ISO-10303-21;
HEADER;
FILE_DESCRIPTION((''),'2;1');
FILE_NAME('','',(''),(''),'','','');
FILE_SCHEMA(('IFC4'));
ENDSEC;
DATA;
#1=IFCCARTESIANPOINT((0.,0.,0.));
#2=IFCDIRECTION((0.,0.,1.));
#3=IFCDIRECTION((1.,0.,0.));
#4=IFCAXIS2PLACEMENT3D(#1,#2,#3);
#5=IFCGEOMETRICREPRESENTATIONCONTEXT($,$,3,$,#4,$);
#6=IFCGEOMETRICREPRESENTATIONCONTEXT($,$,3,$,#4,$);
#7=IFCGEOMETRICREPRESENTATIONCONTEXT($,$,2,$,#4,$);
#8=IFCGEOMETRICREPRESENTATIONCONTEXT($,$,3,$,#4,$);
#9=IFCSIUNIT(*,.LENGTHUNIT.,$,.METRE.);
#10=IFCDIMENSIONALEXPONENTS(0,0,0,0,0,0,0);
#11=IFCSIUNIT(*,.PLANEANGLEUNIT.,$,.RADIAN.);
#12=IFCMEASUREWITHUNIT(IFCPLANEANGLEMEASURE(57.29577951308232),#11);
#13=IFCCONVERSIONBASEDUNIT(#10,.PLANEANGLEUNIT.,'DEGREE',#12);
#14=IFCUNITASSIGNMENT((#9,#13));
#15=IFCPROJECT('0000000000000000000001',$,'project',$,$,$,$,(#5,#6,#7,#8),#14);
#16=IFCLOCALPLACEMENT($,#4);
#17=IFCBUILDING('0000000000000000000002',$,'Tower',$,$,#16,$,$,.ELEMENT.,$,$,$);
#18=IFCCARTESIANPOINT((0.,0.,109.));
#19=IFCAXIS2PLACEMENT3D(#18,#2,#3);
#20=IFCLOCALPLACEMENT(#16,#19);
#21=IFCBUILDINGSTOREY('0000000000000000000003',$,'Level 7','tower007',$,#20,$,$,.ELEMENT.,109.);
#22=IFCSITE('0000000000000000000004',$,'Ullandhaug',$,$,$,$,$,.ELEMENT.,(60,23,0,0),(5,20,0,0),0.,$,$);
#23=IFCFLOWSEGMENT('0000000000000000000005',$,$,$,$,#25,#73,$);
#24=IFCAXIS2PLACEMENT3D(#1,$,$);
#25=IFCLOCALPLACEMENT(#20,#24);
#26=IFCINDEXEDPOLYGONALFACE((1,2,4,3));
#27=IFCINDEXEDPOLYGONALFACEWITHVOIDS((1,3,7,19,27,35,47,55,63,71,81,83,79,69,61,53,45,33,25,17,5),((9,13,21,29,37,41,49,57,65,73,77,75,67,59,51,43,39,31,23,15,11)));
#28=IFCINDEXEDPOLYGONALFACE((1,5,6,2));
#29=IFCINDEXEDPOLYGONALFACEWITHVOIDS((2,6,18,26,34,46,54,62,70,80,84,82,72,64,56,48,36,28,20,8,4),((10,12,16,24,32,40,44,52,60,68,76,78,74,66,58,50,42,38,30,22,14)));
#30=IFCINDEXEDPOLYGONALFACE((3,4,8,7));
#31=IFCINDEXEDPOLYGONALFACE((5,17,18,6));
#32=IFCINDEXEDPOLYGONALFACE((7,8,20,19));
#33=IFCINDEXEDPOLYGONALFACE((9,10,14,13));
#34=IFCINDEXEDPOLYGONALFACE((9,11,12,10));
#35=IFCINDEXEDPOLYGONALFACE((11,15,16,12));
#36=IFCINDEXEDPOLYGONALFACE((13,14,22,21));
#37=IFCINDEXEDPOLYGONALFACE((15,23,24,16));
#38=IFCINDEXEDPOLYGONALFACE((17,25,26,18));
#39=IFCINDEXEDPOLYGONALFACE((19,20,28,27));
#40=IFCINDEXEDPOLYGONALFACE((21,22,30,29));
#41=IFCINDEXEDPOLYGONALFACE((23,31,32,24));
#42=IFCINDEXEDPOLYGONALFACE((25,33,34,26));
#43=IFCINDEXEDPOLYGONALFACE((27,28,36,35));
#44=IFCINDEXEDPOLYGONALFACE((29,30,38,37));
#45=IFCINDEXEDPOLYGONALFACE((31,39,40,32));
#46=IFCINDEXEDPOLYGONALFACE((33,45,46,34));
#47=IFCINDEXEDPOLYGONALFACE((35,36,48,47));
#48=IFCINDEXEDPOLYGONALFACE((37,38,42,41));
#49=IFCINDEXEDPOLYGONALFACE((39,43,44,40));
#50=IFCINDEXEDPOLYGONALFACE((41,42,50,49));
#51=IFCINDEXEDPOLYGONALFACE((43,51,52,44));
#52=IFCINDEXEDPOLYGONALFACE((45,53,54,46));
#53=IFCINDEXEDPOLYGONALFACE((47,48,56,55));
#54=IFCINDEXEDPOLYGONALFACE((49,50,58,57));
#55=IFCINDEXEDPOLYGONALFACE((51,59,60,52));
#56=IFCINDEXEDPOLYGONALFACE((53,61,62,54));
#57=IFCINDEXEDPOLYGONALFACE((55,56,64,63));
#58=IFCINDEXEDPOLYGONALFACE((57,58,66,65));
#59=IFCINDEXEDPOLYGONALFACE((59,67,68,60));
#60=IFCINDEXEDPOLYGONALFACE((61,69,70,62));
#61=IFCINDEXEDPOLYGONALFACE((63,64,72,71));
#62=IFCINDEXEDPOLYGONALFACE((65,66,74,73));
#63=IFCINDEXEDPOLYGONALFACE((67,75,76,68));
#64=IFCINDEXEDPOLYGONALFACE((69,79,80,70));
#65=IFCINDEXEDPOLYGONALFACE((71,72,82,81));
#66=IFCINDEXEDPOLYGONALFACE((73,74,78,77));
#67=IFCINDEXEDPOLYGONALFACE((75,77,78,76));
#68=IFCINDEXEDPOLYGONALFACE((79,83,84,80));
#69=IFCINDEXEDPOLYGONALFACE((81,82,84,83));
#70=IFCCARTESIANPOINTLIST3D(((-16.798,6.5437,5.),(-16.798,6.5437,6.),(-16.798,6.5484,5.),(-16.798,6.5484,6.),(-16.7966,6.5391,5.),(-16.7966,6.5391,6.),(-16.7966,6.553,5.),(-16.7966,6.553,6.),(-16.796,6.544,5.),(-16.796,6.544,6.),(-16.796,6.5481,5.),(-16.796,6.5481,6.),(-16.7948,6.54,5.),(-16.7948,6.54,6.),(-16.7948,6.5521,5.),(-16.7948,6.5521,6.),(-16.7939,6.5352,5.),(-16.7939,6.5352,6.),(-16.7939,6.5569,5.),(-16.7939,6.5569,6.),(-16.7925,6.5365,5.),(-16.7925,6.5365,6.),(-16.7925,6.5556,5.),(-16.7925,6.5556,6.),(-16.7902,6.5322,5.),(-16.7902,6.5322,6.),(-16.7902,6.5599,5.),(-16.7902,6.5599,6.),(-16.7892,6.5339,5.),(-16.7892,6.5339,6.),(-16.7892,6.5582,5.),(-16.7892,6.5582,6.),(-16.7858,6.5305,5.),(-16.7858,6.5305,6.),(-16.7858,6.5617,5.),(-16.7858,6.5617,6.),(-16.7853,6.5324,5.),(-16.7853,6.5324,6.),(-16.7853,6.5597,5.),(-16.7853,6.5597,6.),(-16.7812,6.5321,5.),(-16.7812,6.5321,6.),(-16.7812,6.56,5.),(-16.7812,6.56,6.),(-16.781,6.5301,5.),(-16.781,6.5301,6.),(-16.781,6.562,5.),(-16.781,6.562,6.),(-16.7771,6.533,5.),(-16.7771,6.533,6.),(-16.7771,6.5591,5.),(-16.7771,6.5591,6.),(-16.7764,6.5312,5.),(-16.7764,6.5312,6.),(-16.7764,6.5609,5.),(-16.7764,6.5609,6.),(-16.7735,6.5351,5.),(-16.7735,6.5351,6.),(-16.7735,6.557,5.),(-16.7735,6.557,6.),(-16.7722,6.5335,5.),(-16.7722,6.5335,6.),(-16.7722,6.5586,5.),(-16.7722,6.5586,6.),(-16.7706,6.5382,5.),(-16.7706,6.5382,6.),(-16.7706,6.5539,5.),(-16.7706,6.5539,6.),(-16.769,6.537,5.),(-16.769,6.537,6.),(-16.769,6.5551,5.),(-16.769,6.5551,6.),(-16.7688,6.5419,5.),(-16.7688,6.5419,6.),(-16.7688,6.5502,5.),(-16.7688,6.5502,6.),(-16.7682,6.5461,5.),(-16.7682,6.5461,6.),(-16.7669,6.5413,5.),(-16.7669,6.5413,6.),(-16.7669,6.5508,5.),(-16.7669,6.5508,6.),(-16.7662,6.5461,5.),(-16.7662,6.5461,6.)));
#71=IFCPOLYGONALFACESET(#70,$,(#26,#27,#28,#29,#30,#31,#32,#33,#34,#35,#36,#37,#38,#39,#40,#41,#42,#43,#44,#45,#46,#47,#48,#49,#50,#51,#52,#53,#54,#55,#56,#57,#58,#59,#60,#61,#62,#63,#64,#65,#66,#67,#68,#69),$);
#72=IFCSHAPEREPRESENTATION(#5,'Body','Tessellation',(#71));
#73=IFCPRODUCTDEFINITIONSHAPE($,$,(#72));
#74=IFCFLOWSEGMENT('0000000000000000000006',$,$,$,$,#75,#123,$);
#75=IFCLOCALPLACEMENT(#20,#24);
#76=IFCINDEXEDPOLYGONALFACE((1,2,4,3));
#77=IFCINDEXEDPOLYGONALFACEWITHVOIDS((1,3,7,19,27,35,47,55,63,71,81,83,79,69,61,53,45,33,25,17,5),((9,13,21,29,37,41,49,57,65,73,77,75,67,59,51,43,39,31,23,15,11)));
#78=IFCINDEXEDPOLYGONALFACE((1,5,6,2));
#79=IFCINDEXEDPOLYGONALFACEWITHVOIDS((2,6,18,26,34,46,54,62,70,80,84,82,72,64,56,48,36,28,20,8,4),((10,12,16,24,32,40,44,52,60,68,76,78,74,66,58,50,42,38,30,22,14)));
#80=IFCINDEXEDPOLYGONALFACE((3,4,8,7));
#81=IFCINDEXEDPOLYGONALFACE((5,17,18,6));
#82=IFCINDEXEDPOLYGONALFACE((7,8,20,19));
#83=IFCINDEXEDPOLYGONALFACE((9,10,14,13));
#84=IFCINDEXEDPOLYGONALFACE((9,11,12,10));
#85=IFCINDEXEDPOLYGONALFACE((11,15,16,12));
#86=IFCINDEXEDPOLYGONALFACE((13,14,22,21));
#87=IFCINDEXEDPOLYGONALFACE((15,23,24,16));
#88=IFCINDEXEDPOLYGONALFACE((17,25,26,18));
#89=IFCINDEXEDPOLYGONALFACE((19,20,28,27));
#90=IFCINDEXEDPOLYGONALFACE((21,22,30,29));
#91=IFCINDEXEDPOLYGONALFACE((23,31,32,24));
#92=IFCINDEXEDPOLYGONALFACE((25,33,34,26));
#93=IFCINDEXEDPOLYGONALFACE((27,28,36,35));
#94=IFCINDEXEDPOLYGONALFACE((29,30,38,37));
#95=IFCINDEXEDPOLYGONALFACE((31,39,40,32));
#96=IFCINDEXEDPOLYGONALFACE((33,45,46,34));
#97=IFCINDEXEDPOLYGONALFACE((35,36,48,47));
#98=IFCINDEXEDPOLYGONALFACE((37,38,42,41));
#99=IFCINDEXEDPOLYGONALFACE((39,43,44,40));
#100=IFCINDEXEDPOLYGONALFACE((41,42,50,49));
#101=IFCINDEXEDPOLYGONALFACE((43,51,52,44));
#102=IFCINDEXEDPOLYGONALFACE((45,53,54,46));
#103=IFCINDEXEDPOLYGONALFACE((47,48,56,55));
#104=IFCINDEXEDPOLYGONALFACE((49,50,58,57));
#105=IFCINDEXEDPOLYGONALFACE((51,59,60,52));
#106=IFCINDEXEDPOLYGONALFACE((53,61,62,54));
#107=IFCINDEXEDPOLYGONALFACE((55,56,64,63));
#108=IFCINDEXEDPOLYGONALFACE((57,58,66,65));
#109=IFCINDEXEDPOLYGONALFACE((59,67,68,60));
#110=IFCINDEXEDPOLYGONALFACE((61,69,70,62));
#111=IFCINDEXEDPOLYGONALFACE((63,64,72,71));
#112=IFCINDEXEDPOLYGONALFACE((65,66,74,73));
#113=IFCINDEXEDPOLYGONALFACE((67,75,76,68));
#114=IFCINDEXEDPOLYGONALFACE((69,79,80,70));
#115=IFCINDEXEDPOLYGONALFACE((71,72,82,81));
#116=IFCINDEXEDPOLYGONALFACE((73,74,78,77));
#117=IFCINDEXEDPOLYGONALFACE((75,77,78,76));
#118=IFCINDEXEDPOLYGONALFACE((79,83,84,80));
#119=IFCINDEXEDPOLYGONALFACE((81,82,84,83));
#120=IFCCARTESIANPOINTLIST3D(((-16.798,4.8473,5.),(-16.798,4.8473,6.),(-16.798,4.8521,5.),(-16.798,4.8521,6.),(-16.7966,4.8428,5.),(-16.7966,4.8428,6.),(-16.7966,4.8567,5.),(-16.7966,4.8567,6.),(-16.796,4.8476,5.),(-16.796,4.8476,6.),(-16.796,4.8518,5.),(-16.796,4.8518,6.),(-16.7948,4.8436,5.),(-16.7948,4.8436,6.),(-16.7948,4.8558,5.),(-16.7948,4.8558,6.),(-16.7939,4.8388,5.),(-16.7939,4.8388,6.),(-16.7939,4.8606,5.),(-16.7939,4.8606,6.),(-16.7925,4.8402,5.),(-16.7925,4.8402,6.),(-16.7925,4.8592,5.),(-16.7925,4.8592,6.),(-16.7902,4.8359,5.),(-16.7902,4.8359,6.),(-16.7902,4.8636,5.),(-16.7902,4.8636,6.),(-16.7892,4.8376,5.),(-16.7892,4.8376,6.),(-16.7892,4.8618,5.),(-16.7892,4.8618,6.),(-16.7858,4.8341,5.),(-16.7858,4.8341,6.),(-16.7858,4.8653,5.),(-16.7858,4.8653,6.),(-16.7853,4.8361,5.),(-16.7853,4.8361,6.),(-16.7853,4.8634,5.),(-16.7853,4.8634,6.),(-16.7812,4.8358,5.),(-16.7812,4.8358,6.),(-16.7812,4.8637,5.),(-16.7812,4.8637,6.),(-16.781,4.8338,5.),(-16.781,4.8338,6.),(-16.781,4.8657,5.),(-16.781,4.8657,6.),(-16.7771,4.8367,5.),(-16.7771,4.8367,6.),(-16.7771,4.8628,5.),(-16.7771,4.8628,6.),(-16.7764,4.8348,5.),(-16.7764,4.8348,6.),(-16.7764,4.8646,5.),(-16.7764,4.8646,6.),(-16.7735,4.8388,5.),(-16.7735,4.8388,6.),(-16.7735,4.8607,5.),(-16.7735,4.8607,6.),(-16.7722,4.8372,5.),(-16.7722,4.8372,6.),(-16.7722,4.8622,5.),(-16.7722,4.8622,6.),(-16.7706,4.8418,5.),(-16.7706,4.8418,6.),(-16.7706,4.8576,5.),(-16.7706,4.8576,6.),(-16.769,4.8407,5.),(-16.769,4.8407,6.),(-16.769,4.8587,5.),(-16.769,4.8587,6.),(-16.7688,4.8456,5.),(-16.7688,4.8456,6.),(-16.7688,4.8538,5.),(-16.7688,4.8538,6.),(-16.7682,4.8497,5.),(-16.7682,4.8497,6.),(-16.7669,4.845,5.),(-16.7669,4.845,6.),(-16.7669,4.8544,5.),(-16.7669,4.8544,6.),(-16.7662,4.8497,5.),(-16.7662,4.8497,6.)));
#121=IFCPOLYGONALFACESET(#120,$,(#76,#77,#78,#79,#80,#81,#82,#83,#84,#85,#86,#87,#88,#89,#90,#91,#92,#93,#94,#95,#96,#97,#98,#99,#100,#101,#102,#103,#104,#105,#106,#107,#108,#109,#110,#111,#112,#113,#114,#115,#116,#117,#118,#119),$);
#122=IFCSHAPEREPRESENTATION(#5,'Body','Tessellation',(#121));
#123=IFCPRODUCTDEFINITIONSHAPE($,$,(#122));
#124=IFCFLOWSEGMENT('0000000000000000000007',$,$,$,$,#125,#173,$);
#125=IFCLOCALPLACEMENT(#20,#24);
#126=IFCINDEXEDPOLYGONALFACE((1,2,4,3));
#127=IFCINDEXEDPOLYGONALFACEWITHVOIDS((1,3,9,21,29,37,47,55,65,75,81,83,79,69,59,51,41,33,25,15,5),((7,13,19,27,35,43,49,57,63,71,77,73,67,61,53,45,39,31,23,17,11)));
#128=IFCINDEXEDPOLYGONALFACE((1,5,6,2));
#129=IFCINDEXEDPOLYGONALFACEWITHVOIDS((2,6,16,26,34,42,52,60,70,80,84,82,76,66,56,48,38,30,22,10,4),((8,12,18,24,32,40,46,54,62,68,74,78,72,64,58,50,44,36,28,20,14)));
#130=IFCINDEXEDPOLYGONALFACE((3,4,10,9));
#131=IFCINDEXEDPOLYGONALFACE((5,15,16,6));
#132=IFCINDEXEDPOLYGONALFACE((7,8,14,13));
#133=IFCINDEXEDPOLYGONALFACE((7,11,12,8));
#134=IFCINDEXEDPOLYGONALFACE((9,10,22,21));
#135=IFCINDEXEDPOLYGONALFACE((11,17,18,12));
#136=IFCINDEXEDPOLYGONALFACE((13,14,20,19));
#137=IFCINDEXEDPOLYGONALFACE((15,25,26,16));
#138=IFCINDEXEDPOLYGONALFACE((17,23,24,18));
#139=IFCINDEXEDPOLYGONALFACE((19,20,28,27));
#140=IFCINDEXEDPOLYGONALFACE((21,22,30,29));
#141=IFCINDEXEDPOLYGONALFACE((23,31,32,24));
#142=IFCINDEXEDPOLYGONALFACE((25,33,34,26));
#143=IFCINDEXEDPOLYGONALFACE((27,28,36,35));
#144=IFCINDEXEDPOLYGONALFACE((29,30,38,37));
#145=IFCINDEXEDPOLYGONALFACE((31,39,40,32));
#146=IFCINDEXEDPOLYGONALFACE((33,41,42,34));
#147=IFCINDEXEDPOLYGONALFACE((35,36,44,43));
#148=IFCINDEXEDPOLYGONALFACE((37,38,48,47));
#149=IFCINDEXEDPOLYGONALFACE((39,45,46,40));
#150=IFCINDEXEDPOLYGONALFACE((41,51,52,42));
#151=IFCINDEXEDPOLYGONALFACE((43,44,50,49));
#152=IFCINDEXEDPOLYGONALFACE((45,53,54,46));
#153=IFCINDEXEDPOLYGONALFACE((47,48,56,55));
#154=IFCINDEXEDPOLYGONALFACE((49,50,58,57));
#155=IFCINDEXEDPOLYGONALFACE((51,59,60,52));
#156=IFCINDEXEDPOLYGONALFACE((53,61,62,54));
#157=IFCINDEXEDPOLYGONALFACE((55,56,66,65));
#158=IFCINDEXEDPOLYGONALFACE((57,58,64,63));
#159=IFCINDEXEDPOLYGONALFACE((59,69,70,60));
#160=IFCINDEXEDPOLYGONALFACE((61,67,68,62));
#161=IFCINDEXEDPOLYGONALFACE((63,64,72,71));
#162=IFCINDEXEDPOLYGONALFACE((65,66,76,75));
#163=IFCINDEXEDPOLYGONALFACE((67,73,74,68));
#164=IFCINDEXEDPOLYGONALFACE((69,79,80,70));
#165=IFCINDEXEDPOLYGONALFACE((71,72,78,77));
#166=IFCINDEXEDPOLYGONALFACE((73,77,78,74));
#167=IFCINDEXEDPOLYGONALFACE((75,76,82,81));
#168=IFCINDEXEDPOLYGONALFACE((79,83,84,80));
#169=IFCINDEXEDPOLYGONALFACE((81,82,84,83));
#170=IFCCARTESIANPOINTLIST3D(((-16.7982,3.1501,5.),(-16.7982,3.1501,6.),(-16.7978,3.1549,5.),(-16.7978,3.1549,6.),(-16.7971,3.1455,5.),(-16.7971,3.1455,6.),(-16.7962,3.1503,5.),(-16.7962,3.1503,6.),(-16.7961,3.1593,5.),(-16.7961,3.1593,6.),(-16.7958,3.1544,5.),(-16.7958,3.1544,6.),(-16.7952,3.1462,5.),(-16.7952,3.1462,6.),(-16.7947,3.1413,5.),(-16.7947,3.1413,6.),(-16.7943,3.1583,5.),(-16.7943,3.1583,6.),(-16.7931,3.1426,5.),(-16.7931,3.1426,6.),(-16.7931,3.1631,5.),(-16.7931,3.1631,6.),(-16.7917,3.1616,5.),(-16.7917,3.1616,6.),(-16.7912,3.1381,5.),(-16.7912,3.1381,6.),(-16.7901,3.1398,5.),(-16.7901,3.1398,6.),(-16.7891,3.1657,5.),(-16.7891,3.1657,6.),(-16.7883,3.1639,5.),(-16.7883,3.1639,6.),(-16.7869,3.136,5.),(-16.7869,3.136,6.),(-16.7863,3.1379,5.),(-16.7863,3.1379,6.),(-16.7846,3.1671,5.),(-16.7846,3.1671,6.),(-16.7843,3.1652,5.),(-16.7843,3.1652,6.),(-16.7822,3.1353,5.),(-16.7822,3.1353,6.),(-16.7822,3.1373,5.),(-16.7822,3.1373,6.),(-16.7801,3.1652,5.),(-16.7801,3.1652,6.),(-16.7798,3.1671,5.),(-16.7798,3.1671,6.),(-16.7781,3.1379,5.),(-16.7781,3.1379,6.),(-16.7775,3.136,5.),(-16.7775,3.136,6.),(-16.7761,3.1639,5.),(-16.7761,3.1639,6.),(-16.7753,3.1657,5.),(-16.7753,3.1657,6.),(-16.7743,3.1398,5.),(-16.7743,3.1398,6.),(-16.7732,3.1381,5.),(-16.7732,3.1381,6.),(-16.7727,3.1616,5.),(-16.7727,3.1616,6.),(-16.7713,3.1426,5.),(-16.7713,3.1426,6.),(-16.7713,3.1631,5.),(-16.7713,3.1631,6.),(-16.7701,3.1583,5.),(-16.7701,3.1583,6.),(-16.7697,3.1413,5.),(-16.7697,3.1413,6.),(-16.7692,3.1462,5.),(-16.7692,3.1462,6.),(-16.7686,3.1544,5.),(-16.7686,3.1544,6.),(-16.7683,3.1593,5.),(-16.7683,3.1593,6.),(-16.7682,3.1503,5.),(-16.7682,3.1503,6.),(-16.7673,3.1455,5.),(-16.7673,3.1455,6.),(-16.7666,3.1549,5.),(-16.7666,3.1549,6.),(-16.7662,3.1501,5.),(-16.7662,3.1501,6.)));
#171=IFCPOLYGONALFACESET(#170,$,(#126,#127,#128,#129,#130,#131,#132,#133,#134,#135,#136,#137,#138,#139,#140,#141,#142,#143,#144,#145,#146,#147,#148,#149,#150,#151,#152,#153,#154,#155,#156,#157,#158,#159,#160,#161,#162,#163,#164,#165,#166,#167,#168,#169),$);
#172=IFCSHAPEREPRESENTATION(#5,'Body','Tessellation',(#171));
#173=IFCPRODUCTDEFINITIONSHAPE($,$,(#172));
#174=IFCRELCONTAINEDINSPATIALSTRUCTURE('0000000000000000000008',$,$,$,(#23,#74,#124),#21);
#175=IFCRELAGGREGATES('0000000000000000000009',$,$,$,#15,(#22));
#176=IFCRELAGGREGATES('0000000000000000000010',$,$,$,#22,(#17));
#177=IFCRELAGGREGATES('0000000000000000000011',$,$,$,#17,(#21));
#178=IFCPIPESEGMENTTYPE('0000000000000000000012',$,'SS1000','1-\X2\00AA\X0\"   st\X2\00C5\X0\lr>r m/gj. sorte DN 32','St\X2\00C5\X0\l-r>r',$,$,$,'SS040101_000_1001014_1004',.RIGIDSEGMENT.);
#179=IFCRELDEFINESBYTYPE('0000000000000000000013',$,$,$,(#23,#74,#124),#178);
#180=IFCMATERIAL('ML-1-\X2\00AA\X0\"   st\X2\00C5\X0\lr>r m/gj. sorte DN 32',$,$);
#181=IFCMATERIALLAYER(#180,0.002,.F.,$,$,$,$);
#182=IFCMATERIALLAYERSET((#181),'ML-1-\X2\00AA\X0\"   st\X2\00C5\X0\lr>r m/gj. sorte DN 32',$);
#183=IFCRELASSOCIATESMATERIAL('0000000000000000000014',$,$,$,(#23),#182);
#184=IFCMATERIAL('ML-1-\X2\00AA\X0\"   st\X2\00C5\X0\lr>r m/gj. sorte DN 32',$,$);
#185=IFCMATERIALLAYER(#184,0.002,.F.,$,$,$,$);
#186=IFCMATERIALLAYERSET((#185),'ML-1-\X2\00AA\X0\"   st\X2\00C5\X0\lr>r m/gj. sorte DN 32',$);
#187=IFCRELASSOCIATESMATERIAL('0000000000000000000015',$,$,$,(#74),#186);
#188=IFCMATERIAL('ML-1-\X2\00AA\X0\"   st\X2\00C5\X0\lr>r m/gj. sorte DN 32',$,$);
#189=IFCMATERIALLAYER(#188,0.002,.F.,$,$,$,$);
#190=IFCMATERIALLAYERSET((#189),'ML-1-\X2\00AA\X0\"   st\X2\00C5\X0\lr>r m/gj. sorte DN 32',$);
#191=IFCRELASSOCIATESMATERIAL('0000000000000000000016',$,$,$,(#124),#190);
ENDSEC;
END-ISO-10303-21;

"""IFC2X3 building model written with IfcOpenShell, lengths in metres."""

from ifc_helpers import new_model, entity, si_unit, converted_unit, frame, origin_with_axes, origin_2d_with_axis, place, context, project, spatial, hollow_circle, extrude, material, layer, layer_set, layer_usage, type_object, element, save


model = new_model("IFC2X3")

# Units and contexts
context_of_model_1 = context(None, 3, world=origin_with_axes())
context_of_model_2 = context(None, 3, world=origin_with_axes())
context_of_model_3 = context(None, 2, world=origin_with_axes())
context_of_model_4 = context(None, 3, world=origin_with_axes())
ifc_project = project(units=[si_unit("LENGTHUNIT", "METRE"), converted_unit("PLANEANGLEUNIT", "DEGREE", entity("IfcPlaneAngleMeasure", 57.29577951308232), si_unit("PLANEANGLEUNIT", "RADIAN"), dimensions=[0, 0, 0, 0, 0, 0, 0])], contexts=[context_of_model_1, context_of_model_2, context_of_model_3, context_of_model_4])

# Site, building, storey
site = spatial("IfcSite", under=ifc_project, Name="Ullandhaug", CompositionType="ELEMENT", RefLatitude=(60, 23, 0, 0), RefLongitude=(5, 20, 0, 0), RefElevation=0.0)
building_placement = place(None, origin_with_axes())
building = spatial("IfcBuilding", under=site, at=building_placement, Name="Tower", CompositionType="ELEMENT")
storey_placement = place(building_placement, frame((0.0, 0.0, 109.0), z_axis=(0.0, 0.0, 1.0), x_axis=(1.0, 0.0, 0.0)))
storey = spatial("IfcBuildingStorey", under=building, at=storey_placement, Name="Level 7", Description="tower007", CompositionType="ELEMENT", Elevation=109.0)

# Flow segments
pipe_segment_type_1 = type_object("IfcPipeSegmentType", Name="SS1000", Description="1-ª\"   stÅlr>r m/gj. sorte DN 32", ApplicableOccurrence="StÅl-r>r", ElementType="SS040101_000_1001014_1004", PredefinedType="RIGIDSEGMENT")
ifc_material_1 = material(Name="ML-1-ª\"   stÅlr>r m/gj. sorte DN 32")
ifc_layer_1 = layer(ifc_material_1, 0.002, ventilated=False)
ifc_layer_set_1 = layer_set([ifc_layer_1], Name="ML-1-ª\"   stÅlr>r m/gj. sorte DN 32")
ifc_layer_usage_1 = layer_usage(ifc_layer_set_1, "AXIS2", "POSITIVE", 0.0)
flow_segment_1_placement = place(storey_placement, frame((-16.7822, 6.5461, 5.0), z_axis=(0.0, 0.0, 1.0), x_axis=(1.0, 0.0, 0.0)))
element("IfcFlowSegment", 1, at=flow_segment_1_placement, inside=storey, type_object=pipe_segment_type_1, material=ifc_layer_usage_1, context=context_of_model_1, shape_type="SweptSolid", body=[
    extrude(hollow_circle(Radius=0.016, WallThickness=0.002, at=origin_2d_with_axis()), origin_with_axes(), (0.0, 0.0, 1.0), 1.0),
])
ifc_material_2 = material(Name="ML-1-ª\"   stÅlr>r m/gj. sorte DN 32")
ifc_layer_2 = layer(ifc_material_2, 0.002, ventilated=False)
ifc_layer_set_2 = layer_set([ifc_layer_2], Name="ML-1-ª\"   stÅlr>r m/gj. sorte DN 32")
ifc_layer_usage_2 = layer_usage(ifc_layer_set_2, "AXIS2", "POSITIVE", 0.0)
flow_segment_2_placement = place(storey_placement, frame((-16.7822, 4.8497, 5.0), z_axis=(0.0, 0.0, 1.0), x_axis=(1.0, 0.0, 0.0)))
element("IfcFlowSegment", 2, at=flow_segment_2_placement, inside=storey, type_object=pipe_segment_type_1, material=ifc_layer_usage_2, context=context_of_model_1, shape_type="SweptSolid", body=[
    extrude(hollow_circle(Radius=0.016, WallThickness=0.002, at=origin_2d_with_axis()), origin_with_axes(), (0.0, 0.0, 1.0), 1.0),
])
ifc_material_3 = material(Name="ML-1-ª\"   stÅlr>r m/gj. sorte DN 32")
ifc_layer_3 = layer(ifc_material_3, 0.002, ventilated=False)
ifc_layer_set_3 = layer_set([ifc_layer_3], Name="ML-1-ª\"   stÅlr>r m/gj. sorte DN 32")
ifc_layer_usage_3 = layer_usage(ifc_layer_set_3, "AXIS2", "POSITIVE", 0.0)
flow_segment_3_placement = place(storey_placement, frame((-16.7822, 3.1513, 5.0), z_axis=(0.0, 0.0, 1.0), x_axis=(0.0, -1.0, 0.0)))
element("IfcFlowSegment", 3, at=flow_segment_3_placement, inside=storey, type_object=pipe_segment_type_1, material=ifc_layer_usage_3, context=context_of_model_1, shape_type="SweptSolid", body=[
    extrude(hollow_circle(Radius=0.016, WallThickness=0.002, at=origin_2d_with_axis()), origin_with_axes(), (0.0, 0.0, 1.0), 1.0),
])

save(model, "model.ifc")
